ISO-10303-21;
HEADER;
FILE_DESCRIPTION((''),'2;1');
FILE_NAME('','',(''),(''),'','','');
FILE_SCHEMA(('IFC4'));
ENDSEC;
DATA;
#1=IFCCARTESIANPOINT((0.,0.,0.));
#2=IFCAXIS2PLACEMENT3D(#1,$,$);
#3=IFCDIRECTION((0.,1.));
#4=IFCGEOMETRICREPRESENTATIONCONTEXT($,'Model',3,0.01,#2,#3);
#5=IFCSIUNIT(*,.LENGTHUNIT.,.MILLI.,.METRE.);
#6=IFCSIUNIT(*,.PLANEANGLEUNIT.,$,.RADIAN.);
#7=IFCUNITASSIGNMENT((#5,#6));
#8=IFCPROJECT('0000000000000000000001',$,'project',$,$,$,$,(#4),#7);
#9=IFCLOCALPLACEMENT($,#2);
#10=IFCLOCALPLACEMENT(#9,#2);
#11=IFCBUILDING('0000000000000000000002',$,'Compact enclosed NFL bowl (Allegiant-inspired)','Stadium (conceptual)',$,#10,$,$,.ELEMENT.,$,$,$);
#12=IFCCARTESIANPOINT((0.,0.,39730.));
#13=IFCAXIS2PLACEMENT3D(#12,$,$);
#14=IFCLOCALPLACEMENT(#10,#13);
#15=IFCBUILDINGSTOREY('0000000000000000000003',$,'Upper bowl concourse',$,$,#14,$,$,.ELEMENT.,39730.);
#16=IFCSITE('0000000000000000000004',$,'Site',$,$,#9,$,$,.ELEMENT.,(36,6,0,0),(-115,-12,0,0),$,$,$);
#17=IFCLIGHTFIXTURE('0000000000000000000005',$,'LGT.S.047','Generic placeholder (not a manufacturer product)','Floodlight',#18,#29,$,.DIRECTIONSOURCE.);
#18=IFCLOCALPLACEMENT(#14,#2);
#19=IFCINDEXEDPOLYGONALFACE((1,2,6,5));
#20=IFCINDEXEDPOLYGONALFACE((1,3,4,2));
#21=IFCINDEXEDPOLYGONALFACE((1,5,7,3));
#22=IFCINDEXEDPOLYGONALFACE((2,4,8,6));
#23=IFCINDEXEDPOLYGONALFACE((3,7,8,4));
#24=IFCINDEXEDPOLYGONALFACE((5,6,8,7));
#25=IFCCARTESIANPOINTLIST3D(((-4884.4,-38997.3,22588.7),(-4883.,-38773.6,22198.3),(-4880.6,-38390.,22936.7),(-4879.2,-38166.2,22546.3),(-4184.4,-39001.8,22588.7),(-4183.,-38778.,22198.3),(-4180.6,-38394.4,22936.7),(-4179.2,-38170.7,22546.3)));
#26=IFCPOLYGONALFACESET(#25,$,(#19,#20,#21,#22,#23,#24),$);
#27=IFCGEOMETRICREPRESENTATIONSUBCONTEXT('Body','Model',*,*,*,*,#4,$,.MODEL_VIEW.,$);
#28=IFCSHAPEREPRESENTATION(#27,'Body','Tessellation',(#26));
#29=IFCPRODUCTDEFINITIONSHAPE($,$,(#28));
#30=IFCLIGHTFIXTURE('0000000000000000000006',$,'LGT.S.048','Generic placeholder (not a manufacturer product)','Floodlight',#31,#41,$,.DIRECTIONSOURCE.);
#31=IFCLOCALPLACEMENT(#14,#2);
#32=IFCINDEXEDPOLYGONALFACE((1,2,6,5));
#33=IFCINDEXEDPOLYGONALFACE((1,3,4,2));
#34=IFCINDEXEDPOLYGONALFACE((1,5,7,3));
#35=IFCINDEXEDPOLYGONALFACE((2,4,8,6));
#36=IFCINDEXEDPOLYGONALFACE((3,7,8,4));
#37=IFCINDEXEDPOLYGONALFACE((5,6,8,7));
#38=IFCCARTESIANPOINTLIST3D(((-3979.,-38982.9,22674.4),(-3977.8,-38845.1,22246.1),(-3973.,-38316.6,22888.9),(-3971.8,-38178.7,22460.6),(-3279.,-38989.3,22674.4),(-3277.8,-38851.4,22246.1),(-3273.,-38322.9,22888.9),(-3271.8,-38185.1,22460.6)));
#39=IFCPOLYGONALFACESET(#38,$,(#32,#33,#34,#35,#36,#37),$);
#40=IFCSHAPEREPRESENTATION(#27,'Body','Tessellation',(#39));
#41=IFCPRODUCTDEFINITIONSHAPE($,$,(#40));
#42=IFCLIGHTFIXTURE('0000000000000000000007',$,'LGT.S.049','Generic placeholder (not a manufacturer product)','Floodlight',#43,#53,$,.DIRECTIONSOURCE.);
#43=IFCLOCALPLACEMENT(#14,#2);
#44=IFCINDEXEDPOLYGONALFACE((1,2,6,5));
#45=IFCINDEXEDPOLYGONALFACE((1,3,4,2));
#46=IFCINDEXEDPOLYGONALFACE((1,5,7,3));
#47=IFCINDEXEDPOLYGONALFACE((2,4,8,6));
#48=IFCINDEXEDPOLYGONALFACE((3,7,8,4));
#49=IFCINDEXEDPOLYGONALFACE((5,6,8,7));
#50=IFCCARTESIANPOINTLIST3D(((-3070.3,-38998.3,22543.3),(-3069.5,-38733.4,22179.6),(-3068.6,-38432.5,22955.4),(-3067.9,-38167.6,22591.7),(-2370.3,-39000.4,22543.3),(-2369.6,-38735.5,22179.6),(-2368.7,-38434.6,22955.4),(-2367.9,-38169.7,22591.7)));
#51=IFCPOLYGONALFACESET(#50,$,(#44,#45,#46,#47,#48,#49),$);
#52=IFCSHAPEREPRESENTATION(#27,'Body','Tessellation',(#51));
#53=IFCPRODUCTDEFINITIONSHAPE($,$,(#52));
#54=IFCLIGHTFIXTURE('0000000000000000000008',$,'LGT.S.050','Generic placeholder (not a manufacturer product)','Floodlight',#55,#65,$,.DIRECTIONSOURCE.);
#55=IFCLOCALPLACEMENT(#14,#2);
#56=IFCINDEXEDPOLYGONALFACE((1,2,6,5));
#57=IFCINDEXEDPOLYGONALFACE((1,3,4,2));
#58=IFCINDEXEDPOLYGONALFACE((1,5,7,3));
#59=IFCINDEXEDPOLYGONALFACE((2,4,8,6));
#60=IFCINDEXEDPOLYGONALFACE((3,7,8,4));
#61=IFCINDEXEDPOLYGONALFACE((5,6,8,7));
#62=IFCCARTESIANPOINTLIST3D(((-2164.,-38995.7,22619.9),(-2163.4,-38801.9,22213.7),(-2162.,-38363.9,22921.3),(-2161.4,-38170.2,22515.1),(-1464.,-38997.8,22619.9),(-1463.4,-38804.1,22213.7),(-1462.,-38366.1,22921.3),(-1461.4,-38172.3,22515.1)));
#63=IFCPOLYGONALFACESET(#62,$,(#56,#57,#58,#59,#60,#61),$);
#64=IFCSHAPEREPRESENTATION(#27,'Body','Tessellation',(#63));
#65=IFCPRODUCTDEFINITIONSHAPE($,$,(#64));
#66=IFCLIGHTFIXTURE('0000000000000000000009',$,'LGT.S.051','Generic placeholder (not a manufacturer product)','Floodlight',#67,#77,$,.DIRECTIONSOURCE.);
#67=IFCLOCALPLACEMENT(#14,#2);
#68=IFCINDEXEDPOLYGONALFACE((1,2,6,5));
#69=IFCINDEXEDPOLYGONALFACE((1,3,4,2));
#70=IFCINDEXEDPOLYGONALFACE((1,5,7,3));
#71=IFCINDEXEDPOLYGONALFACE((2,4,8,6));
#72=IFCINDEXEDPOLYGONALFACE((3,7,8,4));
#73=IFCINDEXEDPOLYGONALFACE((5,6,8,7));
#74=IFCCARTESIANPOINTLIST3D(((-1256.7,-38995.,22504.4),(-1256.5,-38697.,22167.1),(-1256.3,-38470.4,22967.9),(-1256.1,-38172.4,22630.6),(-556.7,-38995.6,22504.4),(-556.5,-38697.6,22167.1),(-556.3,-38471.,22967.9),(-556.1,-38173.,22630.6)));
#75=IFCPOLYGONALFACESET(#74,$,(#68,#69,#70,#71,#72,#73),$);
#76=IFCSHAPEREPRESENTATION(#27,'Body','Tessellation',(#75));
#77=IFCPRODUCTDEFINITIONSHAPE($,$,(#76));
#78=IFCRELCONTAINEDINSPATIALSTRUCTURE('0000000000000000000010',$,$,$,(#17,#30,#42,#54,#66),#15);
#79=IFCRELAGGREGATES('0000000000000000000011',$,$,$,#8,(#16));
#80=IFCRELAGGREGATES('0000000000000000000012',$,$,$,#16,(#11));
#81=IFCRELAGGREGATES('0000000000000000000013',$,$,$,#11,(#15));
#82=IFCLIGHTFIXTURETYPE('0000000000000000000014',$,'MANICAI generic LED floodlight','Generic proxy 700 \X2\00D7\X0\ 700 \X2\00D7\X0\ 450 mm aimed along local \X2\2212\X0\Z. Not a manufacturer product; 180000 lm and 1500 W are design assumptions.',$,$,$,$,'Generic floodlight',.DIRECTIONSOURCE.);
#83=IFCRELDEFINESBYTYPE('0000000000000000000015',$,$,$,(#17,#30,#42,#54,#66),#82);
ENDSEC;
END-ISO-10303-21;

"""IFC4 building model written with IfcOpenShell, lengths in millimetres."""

from ifc_helpers import new_model, si_unit, direction, frame, origin, place, context, subcontext, project, spatial, rectangle, extrude, source, transform, mapped, type_object, type_shapes, element, save


model = new_model("IFC4")

# Units and contexts
model_context = context("Model", 3, precision=0.01, world=origin(), true_north=direction((0.0, 1.0)))
body_context = subcontext(model_context, "Body", "Model", "MODEL_VIEW")
ifc_project = project(units=[si_unit("LENGTHUNIT", "METRE", prefix="MILLI"), si_unit("PLANEANGLEUNIT", "RADIAN")], contexts=[model_context])

# Site, building, storey
site_placement = place(None, origin())
site = spatial("IfcSite", under=ifc_project, at=site_placement, Name="Site", CompositionType="ELEMENT", RefLatitude=(36, 6, 0, 0), RefLongitude=(-115, -12, 0, 0))
building_placement = place(site_placement, origin())
building = spatial("IfcBuilding", under=site, at=building_placement, Name="Compact enclosed NFL bowl (Allegiant-inspired)", Description="Stadium (conceptual)", CompositionType="ELEMENT")
storey_placement = place(building_placement, frame((0.0, 0.0, 39730.0)))
storey = spatial("IfcBuildingStorey", under=building, at=storey_placement, Name="Upper bowl concourse", CompositionType="ELEMENT", Elevation=39730.0)

# Light fixtures
light_fixture_type = type_object("IfcLightFixtureType", Name="MANICAI generic LED floodlight", Description="Generic proxy 700 × 700 × 450 mm aimed along local −Z. Not a manufacturer product; 180000 lm and 1500 W are design assumptions.", ElementType="Generic floodlight", PredefinedType="DIRECTIONSOURCE")
shared_shape = source(origin(), body_context, "Body", "SweptSolid", [
    extrude(rectangle(XDim=700.0, YDim=700.0), frame((0.0, 0.0, -225.0)), (0.0, 0.0, 1.0), 450.0),
])
type_shapes(light_fixture_type, [shared_shape])
for number, where, z_axis, x_axis, name in (
    (1, (-4531.8, -38584.0, 22567.5), (-0.003156, -0.497186, 0.867638), (0.99998, -0.006347, 0.0), "LGT.S.047"),
    (2, (-3625.4, -38584.0, 22567.5), (-0.00277, -0.306383, 0.951904), (0.999959, -0.00904, 0.0), "LGT.S.048"),
    (3, (-2719.1, -38584.0, 22567.5), (-0.001764, -0.588696, 0.808353), (0.999996, -0.002997, 0.0), "LGT.S.049"),
    (4, (-1812.7, -38584.0, 22567.5), (-0.001313, -0.430599, 0.902543), (0.999995, -0.003049, 0.0), "LGT.S.050"),
    (5, (-906.4, -38584.0, 22567.5), (-0.000545, -0.662104, 0.749412), (1.0, -0.000823, 0.0), "LGT.S.051"),
):
    element("IfcLightFixture", number, at=place(storey_placement, frame(where, z_axis=z_axis, x_axis=x_axis)), inside=storey, type_object=light_fixture_type, Name=name, Description="Generic placeholder (not a manufacturer product)", ObjectType="Floodlight", PredefinedType="DIRECTIONSOURCE", context=body_context, shape_type="MappedRepresentation", body=[
        mapped(shared_shape, transform((0.0, 0.0, 0.0))),
    ])

save(model, "model.ifc")
